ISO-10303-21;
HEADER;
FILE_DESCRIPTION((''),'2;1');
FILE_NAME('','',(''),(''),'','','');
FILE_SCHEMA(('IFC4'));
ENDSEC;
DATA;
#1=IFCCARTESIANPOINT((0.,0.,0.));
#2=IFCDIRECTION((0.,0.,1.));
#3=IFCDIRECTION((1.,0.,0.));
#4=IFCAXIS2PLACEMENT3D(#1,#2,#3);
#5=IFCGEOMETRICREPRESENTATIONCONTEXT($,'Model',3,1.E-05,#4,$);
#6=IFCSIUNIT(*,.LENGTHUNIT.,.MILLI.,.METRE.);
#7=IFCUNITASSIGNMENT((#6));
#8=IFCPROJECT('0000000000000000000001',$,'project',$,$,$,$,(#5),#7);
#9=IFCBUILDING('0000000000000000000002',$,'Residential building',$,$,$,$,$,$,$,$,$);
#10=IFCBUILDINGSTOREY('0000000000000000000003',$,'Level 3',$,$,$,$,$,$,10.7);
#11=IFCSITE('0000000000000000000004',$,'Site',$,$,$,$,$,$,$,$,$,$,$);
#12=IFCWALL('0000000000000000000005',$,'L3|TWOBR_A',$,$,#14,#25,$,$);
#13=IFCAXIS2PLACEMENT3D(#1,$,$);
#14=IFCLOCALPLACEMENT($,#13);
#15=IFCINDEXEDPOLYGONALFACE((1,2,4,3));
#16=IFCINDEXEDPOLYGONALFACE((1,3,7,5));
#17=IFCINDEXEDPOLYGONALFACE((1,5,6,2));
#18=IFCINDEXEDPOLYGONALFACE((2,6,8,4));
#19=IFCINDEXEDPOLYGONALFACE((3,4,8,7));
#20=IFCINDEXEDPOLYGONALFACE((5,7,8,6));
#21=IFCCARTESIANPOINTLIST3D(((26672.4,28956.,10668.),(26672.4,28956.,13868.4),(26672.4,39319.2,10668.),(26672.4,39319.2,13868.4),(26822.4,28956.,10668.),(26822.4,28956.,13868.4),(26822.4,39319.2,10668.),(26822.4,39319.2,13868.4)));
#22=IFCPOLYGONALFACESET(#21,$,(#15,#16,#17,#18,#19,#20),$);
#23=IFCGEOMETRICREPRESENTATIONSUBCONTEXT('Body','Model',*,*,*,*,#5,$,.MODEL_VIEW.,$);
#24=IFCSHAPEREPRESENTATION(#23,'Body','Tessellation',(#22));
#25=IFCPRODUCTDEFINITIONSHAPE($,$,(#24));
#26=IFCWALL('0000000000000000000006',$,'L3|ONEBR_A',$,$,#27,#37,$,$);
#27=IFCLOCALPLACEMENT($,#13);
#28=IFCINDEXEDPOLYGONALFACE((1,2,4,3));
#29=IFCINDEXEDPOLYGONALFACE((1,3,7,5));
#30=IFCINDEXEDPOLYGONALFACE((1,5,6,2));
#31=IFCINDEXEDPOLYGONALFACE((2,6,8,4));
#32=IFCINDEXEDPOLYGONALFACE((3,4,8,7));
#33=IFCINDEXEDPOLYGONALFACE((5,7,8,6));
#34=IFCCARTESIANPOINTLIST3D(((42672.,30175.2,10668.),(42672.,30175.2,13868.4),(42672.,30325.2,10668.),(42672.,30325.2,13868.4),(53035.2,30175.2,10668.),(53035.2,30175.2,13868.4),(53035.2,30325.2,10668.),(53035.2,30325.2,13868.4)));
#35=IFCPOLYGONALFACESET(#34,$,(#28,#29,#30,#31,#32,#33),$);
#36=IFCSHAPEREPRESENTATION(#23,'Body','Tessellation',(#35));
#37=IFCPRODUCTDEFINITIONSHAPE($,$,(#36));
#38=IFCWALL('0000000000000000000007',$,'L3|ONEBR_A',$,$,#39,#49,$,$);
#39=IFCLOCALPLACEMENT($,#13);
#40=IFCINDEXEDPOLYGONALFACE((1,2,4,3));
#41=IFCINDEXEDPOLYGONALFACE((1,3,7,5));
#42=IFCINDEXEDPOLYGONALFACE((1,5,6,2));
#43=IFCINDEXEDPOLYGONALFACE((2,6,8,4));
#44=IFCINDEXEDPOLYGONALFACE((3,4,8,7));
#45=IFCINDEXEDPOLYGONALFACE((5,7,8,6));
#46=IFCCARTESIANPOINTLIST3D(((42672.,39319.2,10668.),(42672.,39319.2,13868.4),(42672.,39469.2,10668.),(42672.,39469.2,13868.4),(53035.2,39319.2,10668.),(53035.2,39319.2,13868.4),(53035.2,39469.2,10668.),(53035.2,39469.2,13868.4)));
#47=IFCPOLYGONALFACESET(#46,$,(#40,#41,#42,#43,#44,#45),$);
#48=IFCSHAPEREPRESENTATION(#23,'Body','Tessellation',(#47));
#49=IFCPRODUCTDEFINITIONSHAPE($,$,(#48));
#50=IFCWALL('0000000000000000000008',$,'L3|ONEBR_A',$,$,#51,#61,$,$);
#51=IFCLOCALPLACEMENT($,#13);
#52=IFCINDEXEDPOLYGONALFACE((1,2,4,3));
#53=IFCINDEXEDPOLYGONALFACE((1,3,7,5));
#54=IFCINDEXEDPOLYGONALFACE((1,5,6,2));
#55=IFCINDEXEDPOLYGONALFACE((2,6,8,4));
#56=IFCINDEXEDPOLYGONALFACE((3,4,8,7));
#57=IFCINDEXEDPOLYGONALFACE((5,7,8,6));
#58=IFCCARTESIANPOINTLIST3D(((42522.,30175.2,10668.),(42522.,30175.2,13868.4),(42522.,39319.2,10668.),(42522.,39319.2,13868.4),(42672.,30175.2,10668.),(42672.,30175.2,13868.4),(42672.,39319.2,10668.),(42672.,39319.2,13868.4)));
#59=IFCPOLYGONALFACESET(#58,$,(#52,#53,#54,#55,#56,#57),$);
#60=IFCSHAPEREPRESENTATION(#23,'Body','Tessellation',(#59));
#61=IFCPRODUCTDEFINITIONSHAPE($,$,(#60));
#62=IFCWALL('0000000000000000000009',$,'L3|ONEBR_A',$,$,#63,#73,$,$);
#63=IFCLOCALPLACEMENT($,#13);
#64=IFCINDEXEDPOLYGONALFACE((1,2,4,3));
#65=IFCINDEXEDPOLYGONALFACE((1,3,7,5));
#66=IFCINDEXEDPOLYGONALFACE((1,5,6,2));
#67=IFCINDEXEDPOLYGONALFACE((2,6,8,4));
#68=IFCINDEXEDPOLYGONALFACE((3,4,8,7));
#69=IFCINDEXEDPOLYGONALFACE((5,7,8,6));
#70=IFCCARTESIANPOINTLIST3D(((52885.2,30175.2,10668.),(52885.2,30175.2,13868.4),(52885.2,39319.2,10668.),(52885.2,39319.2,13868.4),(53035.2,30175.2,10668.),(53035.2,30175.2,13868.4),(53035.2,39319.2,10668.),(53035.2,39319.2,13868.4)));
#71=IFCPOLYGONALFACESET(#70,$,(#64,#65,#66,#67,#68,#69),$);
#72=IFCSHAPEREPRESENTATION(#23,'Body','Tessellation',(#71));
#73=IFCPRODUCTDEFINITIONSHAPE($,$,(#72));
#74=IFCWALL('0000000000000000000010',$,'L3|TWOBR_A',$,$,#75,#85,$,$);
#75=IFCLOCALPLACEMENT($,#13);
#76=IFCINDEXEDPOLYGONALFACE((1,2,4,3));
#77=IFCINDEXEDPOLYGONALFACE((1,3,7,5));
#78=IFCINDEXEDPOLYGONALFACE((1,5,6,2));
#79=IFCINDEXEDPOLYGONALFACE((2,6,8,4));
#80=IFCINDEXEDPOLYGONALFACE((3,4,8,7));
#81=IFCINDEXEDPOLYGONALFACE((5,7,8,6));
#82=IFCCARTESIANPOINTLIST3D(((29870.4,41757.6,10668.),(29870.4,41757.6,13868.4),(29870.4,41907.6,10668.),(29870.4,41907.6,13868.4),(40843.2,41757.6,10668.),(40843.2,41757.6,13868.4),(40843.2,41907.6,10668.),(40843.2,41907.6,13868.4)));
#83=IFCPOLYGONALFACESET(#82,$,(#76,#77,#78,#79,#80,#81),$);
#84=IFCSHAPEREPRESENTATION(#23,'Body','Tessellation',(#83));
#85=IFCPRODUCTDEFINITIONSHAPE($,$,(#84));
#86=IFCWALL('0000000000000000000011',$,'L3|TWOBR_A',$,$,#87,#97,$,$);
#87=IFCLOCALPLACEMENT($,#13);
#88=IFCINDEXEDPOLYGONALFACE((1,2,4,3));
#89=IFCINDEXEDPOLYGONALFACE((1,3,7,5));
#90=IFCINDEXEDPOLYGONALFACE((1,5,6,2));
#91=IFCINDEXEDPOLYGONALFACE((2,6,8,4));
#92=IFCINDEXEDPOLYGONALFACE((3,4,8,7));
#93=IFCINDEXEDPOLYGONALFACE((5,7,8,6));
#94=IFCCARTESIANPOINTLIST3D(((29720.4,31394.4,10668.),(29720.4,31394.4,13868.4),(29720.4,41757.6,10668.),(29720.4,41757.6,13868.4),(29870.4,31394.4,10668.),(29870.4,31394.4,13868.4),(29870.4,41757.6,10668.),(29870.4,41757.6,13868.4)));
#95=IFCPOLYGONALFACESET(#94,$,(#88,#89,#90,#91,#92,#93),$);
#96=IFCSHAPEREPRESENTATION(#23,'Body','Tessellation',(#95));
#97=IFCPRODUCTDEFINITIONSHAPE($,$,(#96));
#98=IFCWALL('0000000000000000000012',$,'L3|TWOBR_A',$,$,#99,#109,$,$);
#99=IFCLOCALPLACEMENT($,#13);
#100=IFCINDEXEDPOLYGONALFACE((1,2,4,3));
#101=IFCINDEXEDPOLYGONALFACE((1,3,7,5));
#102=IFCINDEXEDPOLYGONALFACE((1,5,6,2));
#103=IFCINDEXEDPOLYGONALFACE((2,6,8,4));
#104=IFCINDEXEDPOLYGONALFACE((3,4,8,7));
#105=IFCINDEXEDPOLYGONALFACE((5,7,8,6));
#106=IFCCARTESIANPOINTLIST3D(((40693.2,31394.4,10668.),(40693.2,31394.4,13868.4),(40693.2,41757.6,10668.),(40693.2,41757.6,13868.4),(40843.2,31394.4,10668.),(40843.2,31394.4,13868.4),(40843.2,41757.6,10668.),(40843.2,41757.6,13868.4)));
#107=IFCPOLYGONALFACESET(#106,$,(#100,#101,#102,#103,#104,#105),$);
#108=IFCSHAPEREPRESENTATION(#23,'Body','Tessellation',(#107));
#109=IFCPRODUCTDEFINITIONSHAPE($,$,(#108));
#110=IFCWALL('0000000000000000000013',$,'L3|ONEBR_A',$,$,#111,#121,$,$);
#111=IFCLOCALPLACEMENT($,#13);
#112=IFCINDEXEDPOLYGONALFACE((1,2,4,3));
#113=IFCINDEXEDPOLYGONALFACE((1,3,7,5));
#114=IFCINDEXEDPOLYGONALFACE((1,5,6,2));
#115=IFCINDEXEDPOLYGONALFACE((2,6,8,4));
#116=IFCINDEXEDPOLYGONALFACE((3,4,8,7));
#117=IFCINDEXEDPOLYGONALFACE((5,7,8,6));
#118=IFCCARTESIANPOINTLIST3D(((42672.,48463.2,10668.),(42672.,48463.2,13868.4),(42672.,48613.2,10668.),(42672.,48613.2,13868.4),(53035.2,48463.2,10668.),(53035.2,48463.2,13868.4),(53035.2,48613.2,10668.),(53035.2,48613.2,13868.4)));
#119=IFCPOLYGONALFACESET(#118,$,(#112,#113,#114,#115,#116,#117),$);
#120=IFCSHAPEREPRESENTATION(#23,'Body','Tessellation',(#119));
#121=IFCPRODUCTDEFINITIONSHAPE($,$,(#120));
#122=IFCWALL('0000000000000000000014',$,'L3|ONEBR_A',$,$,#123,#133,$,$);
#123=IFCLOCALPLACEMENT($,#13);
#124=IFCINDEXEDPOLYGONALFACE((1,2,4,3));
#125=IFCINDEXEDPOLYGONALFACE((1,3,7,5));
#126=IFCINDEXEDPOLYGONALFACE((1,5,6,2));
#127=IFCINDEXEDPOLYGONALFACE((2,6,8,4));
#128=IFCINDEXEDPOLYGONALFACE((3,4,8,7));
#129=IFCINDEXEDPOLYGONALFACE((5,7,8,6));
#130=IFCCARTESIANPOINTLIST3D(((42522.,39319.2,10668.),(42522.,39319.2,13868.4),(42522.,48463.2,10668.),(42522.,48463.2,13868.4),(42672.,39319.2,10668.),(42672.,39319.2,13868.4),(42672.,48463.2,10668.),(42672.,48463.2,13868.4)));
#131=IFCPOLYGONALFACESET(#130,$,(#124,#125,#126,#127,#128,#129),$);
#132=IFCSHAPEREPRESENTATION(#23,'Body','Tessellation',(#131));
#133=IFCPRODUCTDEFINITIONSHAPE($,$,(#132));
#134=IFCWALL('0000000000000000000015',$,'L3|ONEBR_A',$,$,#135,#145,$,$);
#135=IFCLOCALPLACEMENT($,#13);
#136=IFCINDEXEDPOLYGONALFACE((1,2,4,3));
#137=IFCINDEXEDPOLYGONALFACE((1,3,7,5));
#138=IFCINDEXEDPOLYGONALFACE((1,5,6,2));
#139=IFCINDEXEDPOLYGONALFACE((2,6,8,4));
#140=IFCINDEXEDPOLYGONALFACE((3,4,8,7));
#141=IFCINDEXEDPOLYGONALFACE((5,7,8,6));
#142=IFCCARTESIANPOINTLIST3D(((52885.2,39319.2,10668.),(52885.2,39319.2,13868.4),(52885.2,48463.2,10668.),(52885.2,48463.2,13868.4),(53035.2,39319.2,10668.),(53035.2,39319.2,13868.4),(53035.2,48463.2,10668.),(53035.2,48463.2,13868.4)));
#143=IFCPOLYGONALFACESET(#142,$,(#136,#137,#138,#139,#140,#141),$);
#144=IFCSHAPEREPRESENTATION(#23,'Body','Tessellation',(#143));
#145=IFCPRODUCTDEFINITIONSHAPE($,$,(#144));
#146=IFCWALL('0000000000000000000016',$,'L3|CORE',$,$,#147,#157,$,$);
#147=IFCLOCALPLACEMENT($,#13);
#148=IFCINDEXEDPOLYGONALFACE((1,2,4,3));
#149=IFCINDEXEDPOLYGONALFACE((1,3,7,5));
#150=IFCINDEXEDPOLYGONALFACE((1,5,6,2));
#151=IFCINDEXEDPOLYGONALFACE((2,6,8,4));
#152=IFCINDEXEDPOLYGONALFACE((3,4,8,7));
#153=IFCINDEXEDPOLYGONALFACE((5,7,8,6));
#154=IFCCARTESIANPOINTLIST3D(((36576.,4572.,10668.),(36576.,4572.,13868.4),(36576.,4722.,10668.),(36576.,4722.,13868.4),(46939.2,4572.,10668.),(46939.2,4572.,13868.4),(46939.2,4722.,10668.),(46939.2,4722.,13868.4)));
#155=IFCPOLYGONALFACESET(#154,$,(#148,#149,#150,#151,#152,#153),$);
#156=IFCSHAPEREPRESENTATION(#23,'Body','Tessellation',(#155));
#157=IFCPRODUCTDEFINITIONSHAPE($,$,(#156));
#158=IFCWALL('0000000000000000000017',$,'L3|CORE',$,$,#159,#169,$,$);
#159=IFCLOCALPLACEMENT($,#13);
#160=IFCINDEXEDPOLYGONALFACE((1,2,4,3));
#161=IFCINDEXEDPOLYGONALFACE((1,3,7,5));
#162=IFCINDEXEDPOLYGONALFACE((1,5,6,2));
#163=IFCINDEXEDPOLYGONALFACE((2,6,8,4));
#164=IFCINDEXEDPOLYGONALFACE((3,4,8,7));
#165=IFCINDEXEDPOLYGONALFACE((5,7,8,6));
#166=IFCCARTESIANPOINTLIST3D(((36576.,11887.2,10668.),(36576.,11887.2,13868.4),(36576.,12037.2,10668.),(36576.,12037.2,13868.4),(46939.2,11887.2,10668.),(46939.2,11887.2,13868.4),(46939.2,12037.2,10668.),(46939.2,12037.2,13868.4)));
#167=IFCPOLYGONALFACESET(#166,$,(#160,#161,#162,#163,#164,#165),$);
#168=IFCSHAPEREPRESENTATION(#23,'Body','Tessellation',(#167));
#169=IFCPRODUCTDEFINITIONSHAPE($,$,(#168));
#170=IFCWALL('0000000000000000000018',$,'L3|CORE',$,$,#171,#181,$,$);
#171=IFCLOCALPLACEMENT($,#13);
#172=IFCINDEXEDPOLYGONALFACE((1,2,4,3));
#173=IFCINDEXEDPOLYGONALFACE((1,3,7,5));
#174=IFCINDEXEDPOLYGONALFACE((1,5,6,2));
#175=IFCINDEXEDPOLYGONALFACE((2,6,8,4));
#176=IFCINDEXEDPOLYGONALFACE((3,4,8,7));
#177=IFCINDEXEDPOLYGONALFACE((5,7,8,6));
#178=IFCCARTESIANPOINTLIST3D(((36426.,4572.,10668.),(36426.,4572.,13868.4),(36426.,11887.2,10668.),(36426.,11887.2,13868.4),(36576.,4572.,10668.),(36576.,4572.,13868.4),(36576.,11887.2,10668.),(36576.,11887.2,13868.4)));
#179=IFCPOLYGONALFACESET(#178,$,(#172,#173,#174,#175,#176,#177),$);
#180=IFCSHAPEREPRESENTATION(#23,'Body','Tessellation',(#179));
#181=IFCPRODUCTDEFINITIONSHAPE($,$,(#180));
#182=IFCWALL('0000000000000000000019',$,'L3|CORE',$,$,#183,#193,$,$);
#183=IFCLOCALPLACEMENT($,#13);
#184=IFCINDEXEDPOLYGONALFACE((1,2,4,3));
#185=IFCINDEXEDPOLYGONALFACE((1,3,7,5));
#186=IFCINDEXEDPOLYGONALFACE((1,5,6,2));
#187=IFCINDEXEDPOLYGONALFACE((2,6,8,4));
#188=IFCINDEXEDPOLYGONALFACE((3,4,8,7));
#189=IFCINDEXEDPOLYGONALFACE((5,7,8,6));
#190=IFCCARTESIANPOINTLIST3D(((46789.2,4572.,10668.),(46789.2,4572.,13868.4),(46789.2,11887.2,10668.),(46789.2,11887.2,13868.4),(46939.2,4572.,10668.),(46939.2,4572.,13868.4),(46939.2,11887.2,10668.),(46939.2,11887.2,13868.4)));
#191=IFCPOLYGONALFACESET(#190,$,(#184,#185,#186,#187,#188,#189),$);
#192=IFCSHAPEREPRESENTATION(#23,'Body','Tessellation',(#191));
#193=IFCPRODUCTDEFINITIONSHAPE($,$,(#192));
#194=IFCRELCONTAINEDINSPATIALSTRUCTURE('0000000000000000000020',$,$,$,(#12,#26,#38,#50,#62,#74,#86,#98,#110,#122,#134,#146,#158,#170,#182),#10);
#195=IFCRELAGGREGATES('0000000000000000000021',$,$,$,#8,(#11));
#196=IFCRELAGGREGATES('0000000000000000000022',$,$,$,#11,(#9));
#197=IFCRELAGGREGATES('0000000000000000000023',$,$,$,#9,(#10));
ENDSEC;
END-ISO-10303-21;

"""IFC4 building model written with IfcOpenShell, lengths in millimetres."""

from ifc_helpers import new_model, si_unit, frame, origin_with_axes, place, context, subcontext, project, spatial, indexed_curve, outline, extrude, element, save


model = new_model("IFC4")

# Units and contexts
model_context = context("Model", 3, precision=1e-05, world=origin_with_axes())
body_context = subcontext(model_context, "Body", "Model", "MODEL_VIEW")
ifc_project = project(units=[si_unit("LENGTHUNIT", "METRE", prefix="MILLI")], contexts=[model_context])

# Site, building, storey
site = spatial("IfcSite", under=ifc_project, Name="Site")
building = spatial("IfcBuilding", under=site, Name="Residential building")
storey = spatial("IfcBuildingStorey", under=building, Name="Level 3", Elevation=10.7)

# Walls
for number, where, z_axis, x_axis, name in (
    (1, (26822.4, 28956.0, 10668.0), (0.0, 0.0, 1.0), (0.0, 1.0, 0.0), "L3|TWOBR_A"),
    (2, (42672.0, 30175.2, 10668.0), (0.0, 0.0, 1.0), (1.0, 0.0, 0.0), "L3|ONEBR_A"),
    (3, (42672.0, 39319.2, 10668.0), (0.0, 0.0, 1.0), (1.0, 0.0, 0.0), "L3|ONEBR_A"),
):
    element("IfcWall", number, at=place(None, frame(where, z_axis=z_axis, x_axis=x_axis)), inside=storey, Name=name, context=body_context, shape_type="SweptSolid", body=[
        extrude(outline(indexed_curve([(0.0, 0.0), (0.0, 150.0), (10363.2, 150.0), (10363.2, 0.0), (0.0, 0.0)], self_intersect=False)), origin_with_axes(), (0.0, 0.0, 1.0), 3200.4),
    ])
for number, where, z_axis, x_axis, name in (
    (4, (42672.0, 30175.2, 10668.0), (0.0, 0.0, 1.0), (0.0, 1.0, 0.0), "L3|ONEBR_A"),
    (5, (53035.2, 30175.2, 10668.0), (0.0, 0.0, 1.0), (0.0, 1.0, 0.0), "L3|ONEBR_A"),
):
    element("IfcWall", number, at=place(None, frame(where, z_axis=z_axis, x_axis=x_axis)), inside=storey, Name=name, context=body_context, shape_type="SweptSolid", body=[
        extrude(outline(indexed_curve([(0.0, 0.0), (0.0, 150.0), (9144.0, 150.0), (9144.0, 0.0), (0.0, 0.0)], self_intersect=False)), origin_with_axes(), (0.0, 0.0, 1.0), 3200.4),
    ])
for number, where, z_axis, x_axis, name in (
    (6, (29870.4, 41757.6, 10668.0), (0.0, 0.0, 1.0), (1.0, 0.0, 0.0), "L3|TWOBR_A"),
):
    element("IfcWall", number, at=place(None, frame(where, z_axis=z_axis, x_axis=x_axis)), inside=storey, Name=name, context=body_context, shape_type="SweptSolid", body=[
        extrude(outline(indexed_curve([(0.0, 0.0), (0.0, 150.0), (10972.8, 150.0), (10972.8, 0.0), (0.0, 0.0)], self_intersect=False)), origin_with_axes(), (0.0, 0.0, 1.0), 3200.4),
    ])
for number, where, z_axis, x_axis, name in (
    (7, (29870.4, 31394.4, 10668.0), (0.0, 0.0, 1.0), (0.0, 1.0, 0.0), "L3|TWOBR_A"),
    (8, (40843.2, 31394.4, 10668.0), (0.0, 0.0, 1.0), (0.0, 1.0, 0.0), "L3|TWOBR_A"),
    (9, (42672.0, 48463.2, 10668.0), (0.0, 0.0, 1.0), (1.0, 0.0, 0.0), "L3|ONEBR_A"),
):
    element("IfcWall", number, at=place(None, frame(where, z_axis=z_axis, x_axis=x_axis)), inside=storey, Name=name, context=body_context, shape_type="SweptSolid", body=[
        extrude(outline(indexed_curve([(0.0, 0.0), (0.0, 150.0), (10363.2, 150.0), (10363.2, 0.0), (0.0, 0.0)], self_intersect=False)), origin_with_axes(), (0.0, 0.0, 1.0), 3200.4),
    ])
for number, where, z_axis, x_axis, name in (
    (10, (42672.0, 39319.2, 10668.0), (0.0, 0.0, 1.0), (0.0, 1.0, 0.0), "L3|ONEBR_A"),
    (11, (53035.2, 39319.2, 10668.0), (0.0, 0.0, 1.0), (0.0, 1.0, 0.0), "L3|ONEBR_A"),
):
    element("IfcWall", number, at=place(None, frame(where, z_axis=z_axis, x_axis=x_axis)), inside=storey, Name=name, context=body_context, shape_type="SweptSolid", body=[
        extrude(outline(indexed_curve([(0.0, 0.0), (0.0, 150.0), (9144.0, 150.0), (9144.0, 0.0), (0.0, 0.0)], self_intersect=False)), origin_with_axes(), (0.0, 0.0, 1.0), 3200.4),
    ])
for number, where, z_axis, x_axis, name in (
    (12, (36576.0, 4572.0, 10668.0), (0.0, 0.0, 1.0), (1.0, 0.0, 0.0), "L3|CORE"),
    (13, (36576.0, 11887.2, 10668.0), (0.0, 0.0, 1.0), (1.0, 0.0, 0.0), "L3|CORE"),
):
    element("IfcWall", number, at=place(None, frame(where, z_axis=z_axis, x_axis=x_axis)), inside=storey, Name=name, context=body_context, shape_type="SweptSolid", body=[
        extrude(outline(indexed_curve([(0.0, 0.0), (0.0, 150.0), (10363.2, 150.0), (10363.2, 0.0), (0.0, 0.0)], self_intersect=False)), origin_with_axes(), (0.0, 0.0, 1.0), 3200.4),
    ])
for number, where, z_axis, x_axis, name in (
    (14, (36576.0, 4572.0, 10668.0), (0.0, 0.0, 1.0), (0.0, 1.0, 0.0), "L3|CORE"),
    (15, (46939.2, 4572.0, 10668.0), (0.0, 0.0, 1.0), (0.0, 1.0, 0.0), "L3|CORE"),
):
    element("IfcWall", number, at=place(None, frame(where, z_axis=z_axis, x_axis=x_axis)), inside=storey, Name=name, context=body_context, shape_type="SweptSolid", body=[
        extrude(outline(indexed_curve([(0.0, 0.0), (0.0, 150.0), (7315.2, 150.0), (7315.2, 0.0), (0.0, 0.0)], self_intersect=False)), origin_with_axes(), (0.0, 0.0, 1.0), 3200.4),
    ])

save(model, "model.ifc")
